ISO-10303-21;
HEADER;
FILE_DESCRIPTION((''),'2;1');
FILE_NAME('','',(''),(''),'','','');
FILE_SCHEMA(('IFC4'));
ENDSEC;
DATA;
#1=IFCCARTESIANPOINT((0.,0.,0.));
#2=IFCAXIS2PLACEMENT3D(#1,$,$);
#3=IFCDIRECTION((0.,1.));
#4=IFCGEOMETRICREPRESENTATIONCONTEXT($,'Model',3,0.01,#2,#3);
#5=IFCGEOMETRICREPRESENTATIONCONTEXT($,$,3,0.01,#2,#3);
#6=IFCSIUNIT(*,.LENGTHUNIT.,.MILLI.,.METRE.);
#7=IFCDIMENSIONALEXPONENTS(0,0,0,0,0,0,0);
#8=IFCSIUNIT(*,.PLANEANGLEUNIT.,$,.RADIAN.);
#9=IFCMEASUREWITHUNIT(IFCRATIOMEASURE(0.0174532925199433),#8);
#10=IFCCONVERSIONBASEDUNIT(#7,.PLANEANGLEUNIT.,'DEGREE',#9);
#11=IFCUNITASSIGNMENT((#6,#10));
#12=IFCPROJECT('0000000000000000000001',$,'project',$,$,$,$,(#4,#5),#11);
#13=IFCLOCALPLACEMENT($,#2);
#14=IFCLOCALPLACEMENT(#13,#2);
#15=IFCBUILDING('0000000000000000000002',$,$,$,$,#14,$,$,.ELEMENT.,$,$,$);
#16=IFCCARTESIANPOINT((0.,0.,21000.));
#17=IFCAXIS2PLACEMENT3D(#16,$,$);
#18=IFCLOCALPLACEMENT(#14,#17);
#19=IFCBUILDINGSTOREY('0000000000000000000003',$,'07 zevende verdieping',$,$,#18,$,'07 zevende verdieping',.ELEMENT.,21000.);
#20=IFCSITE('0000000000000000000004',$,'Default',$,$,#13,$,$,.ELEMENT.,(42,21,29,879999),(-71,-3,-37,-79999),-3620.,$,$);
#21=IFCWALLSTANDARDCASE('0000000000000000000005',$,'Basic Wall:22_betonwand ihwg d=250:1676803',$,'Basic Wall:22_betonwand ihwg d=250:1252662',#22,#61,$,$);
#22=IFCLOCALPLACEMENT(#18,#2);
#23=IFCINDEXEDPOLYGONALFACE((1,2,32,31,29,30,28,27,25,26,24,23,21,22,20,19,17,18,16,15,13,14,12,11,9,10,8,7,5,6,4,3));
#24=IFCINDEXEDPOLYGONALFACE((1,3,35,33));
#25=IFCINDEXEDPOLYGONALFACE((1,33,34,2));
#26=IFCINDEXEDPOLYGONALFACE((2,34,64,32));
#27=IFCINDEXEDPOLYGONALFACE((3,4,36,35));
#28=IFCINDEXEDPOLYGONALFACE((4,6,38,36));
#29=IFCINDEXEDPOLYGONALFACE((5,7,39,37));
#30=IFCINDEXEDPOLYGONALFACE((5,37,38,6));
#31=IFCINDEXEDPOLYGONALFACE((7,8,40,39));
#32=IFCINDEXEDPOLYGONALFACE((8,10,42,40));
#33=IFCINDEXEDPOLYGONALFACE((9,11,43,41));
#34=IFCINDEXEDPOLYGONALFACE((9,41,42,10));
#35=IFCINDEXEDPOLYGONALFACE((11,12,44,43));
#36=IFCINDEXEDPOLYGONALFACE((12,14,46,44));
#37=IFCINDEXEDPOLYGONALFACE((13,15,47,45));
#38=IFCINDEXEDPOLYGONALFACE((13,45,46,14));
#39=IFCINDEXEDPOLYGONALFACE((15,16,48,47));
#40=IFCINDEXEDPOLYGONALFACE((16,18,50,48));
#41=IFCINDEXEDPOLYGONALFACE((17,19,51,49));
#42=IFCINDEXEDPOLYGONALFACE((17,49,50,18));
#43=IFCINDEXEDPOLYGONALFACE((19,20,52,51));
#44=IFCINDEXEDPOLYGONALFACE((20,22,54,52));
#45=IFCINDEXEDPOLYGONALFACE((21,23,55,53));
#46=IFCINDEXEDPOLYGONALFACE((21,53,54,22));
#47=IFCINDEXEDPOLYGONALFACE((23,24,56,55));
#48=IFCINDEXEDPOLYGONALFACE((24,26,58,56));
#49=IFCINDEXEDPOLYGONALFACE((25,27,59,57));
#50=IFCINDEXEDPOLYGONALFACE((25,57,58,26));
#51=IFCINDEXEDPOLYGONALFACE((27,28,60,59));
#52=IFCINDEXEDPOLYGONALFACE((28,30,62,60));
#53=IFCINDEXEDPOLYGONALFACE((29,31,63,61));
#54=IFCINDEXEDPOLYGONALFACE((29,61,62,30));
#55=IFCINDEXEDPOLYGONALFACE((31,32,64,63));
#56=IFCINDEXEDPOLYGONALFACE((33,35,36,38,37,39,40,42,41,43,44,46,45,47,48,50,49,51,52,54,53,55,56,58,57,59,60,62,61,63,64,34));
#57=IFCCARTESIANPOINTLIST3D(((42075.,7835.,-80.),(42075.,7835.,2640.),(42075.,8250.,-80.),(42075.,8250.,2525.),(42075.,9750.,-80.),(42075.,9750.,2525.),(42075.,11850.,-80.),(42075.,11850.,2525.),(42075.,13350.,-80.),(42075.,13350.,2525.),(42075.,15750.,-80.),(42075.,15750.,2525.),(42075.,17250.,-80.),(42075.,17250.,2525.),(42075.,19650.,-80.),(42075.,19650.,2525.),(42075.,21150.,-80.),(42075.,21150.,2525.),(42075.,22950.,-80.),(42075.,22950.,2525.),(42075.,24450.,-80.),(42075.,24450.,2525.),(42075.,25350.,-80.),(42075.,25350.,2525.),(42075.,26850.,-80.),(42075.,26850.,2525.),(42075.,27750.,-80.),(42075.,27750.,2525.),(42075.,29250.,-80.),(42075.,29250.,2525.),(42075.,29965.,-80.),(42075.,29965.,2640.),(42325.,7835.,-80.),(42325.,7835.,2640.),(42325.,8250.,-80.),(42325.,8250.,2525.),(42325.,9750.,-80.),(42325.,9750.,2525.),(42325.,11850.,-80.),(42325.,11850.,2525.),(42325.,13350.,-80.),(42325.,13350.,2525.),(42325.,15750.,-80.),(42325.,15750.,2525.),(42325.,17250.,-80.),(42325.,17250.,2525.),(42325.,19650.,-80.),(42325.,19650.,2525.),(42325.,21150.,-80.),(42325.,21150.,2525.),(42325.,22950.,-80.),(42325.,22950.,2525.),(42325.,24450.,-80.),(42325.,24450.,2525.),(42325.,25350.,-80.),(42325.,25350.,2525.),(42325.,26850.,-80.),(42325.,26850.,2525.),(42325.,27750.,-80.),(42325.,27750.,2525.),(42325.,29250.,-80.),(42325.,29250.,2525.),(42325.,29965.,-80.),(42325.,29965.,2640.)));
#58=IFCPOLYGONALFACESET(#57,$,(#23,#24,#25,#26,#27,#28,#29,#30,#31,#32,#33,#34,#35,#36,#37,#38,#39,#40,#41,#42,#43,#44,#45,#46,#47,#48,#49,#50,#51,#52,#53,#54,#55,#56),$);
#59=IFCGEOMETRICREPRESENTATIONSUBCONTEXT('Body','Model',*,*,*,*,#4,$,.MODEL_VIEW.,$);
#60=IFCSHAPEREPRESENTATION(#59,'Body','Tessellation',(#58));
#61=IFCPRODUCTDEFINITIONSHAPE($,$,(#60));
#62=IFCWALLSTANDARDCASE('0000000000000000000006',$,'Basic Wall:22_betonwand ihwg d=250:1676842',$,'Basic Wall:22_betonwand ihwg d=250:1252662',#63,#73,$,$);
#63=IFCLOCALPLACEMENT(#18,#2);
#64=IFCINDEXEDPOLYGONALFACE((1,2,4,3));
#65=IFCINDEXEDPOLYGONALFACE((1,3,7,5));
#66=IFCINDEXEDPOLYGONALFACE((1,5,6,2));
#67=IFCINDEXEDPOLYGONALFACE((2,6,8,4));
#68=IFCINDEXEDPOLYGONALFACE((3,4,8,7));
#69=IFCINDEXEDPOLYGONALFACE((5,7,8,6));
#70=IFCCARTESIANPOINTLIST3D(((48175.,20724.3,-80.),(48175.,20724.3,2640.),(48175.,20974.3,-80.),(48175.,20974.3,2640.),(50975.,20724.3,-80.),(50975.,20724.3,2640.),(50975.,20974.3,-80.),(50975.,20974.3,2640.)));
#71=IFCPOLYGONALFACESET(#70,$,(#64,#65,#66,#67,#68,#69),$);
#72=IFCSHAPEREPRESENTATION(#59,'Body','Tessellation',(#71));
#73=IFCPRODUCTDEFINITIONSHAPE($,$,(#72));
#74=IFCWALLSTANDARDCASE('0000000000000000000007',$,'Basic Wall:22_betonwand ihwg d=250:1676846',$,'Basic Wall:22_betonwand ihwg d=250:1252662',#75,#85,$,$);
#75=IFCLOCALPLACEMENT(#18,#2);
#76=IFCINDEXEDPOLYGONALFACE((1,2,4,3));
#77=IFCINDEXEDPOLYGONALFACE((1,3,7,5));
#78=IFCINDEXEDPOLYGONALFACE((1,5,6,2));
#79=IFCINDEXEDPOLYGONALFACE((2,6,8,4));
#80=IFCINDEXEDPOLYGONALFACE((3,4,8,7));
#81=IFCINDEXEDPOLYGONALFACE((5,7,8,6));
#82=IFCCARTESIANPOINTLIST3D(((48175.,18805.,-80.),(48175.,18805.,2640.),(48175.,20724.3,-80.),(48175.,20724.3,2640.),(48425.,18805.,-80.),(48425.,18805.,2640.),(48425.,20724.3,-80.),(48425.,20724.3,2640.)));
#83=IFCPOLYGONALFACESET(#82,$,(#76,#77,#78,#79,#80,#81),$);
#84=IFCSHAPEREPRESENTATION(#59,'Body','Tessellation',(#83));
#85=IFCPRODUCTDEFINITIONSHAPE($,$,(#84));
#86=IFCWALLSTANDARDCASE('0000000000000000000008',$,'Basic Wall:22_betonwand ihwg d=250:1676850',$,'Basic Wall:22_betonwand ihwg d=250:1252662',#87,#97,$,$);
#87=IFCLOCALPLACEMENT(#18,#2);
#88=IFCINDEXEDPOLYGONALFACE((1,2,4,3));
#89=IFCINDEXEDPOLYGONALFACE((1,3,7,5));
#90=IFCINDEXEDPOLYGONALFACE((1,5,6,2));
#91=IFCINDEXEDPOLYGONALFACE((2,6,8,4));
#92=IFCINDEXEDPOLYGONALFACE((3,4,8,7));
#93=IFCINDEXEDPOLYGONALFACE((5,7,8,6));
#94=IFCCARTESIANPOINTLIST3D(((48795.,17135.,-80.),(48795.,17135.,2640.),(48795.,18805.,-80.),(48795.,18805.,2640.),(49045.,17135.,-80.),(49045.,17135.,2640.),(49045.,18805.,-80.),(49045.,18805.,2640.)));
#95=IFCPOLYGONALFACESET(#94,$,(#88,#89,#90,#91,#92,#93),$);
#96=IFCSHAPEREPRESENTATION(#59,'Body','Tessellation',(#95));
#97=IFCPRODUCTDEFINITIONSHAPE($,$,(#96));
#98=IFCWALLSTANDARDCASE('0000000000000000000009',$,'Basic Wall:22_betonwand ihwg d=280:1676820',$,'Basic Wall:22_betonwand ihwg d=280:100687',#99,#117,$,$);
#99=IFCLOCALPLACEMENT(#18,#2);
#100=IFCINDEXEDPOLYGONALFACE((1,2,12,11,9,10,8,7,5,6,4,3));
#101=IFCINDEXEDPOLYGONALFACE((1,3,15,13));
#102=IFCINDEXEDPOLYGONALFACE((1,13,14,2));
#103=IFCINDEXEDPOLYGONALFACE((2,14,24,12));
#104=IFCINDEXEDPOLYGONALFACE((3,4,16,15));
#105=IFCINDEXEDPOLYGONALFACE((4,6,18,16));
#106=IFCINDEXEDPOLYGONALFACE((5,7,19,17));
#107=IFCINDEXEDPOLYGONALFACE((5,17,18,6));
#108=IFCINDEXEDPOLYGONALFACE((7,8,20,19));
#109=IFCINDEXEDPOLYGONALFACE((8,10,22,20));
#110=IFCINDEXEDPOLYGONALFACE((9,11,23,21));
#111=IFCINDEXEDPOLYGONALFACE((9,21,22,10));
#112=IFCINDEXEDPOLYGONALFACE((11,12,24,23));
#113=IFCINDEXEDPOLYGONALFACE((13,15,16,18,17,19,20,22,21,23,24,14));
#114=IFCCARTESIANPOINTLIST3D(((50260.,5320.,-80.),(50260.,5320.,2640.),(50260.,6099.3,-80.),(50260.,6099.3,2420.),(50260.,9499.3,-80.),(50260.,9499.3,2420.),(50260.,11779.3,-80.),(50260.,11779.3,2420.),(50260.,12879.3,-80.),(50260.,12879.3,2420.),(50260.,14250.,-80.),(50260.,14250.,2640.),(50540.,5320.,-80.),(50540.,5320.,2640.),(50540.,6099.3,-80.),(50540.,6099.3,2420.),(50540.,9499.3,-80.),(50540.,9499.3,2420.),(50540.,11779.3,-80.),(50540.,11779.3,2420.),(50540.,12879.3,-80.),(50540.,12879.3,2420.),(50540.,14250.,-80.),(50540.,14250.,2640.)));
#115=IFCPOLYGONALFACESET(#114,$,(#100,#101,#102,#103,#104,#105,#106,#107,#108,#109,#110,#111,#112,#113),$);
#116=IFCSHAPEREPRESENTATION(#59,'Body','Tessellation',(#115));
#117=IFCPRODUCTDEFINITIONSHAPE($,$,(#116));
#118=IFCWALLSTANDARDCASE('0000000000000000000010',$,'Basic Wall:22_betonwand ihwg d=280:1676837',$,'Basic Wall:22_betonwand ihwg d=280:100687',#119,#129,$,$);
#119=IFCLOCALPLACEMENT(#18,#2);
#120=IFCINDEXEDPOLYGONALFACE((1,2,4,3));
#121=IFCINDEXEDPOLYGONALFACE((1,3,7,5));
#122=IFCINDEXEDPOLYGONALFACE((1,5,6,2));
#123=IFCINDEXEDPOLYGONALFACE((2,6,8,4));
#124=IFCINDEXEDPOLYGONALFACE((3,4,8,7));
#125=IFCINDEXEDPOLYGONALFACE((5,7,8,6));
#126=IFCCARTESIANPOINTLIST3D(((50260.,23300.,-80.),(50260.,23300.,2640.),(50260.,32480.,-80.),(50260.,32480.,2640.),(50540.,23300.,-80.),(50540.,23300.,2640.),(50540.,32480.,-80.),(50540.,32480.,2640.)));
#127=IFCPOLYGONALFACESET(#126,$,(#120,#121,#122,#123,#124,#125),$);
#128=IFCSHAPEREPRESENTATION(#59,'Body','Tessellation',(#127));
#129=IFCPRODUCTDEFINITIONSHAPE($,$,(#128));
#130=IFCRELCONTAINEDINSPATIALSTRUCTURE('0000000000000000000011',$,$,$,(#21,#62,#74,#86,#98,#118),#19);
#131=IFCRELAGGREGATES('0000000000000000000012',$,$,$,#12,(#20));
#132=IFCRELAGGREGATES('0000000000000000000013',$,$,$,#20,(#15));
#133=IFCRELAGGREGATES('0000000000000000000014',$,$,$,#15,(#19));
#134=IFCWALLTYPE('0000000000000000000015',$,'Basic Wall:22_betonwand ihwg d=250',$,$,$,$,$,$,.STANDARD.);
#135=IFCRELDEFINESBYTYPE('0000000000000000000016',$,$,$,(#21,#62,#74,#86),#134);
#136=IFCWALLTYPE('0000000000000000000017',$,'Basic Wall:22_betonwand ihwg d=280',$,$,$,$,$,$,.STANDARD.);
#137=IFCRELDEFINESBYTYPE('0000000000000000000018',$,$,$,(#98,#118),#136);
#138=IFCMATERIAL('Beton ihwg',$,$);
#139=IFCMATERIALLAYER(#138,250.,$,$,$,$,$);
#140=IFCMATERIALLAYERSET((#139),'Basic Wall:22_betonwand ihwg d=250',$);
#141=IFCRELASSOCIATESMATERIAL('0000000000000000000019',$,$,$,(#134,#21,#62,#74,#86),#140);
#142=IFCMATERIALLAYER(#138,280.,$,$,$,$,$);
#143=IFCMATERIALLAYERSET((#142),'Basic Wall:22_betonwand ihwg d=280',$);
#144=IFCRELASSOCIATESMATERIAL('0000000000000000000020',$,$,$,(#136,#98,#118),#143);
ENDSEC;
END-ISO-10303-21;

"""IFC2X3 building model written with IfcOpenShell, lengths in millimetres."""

from ifc_helpers import new_model, entity, si_unit, converted_unit, direction, frame, frame_2d, origin, place, context, subcontext, project, spatial, rectangle, extrude, material, layer, layer_set, layer_usage, type_object, element, save


model = new_model("IFC2X3")

# Units and contexts
model_context = context("Model", 3, precision=0.01, world=origin(), true_north=direction((0.0, 1.0)))
context_of_model = context(None, 3, precision=0.01, world=origin(), true_north=direction((0.0, 1.0)))
body_context = subcontext(model_context, "Body", "Model", "MODEL_VIEW")
ifc_project = project(units=[si_unit("LENGTHUNIT", "METRE", prefix="MILLI"), converted_unit("PLANEANGLEUNIT", "DEGREE", entity("IfcRatioMeasure", 0.0174532925199433), si_unit("PLANEANGLEUNIT", "RADIAN"), dimensions=[0, 0, 0, 0, 0, 0, 0])], contexts=[model_context, context_of_model])

# Site, building, storey
site_placement = place(None, origin())
site = spatial("IfcSite", under=ifc_project, at=site_placement, Name="Default", CompositionType="ELEMENT", RefLatitude=(42, 21, 29, 879999), RefLongitude=(-71, -3, -37, -79999), RefElevation=-3620.0)
building_placement = place(site_placement, origin())
building = spatial("IfcBuilding", under=site, at=building_placement, CompositionType="ELEMENT")
storey_placement = place(building_placement, frame((0.0, 0.0, 21000.0)))
storey = spatial("IfcBuildingStorey", under=building, at=storey_placement, Name="07 zevende verdieping", LongName="07 zevende verdieping", CompositionType="ELEMENT", Elevation=21000.0)

# Shared definitions
ifc_material_1 = material(Name="Beton ihwg")

# Wall, openings
ifc_layer_1 = layer(ifc_material_1, 250.0)
ifc_layer_set_1 = layer_set([ifc_layer_1], Name="Basic Wall:22_betonwand ihwg d=250")
ifc_layer_usage_1 = layer_usage(ifc_layer_set_1, "AXIS2", "POSITIVE", -125.0)
wall_type_1 = type_object("IfcWallType", Name="Basic Wall:22_betonwand ihwg d=250", PredefinedType="STANDARD", material=ifc_layer_set_1)
wall_1_placement = place(storey_placement, frame((42200.0, 29965.0, -80.0), z_axis=(0.0, 0.0, 1.0), x_axis=(0.0, -1.0, 0.0)))
wall_1 = element("IfcWallStandardCase", 1, at=wall_1_placement, inside=storey, type_object=wall_type_1, material=ifc_layer_usage_1, Name="Basic Wall:22_betonwand ihwg d=250:1676803", ObjectType="Basic Wall:22_betonwand ihwg d=250:1252662", context=body_context, shape_type="SweptSolid", body=[
    extrude(rectangle(XDim=22130.0, YDim=250.0, at=frame_2d((11065.0, 0.0), x_axis=(-1.0, 0.0))), origin(), (0.0, 0.0, 1.0), 2720.0),
])
opening_1_placement = place(wall_1_placement, frame((29965.0, -42200.0, 80.0), z_axis=(0.0, 0.0, 1.0), x_axis=(0.0, 1.0, 0.0)))
element("IfcOpeningElement", 2, at=opening_1_placement, cuts=wall_1, ObjectType="Opening", context=body_context, shape_type="SweptSolid", body=[
    extrude(rectangle(XDim=2605.0, YDim=1500.0, at=frame_2d((0.0, 0.0), x_axis=(1.0, 0.0))), frame((40801.0, 28500.0, 1222.5), z_axis=(1.0, 0.0, 0.0), x_axis=(0.0, 0.0, -1.0)), (0.0, 0.0, 1.0), 3048.0),
])
opening_2_placement = place(wall_1_placement, frame((29965.0, -42200.0, 80.0), z_axis=(0.0, 0.0, 1.0), x_axis=(0.0, 1.0, 0.0)))
element("IfcOpeningElement", 3, at=opening_2_placement, cuts=wall_1, ObjectType="Opening", context=body_context, shape_type="SweptSolid", body=[
    extrude(rectangle(XDim=2605.0, YDim=1500.0, at=frame_2d((0.0, 0.0), x_axis=(1.0, 0.0))), frame((40801.0, 26100.0, 1222.5), z_axis=(1.0, 0.0, 0.0), x_axis=(0.0, 0.0, -1.0)), (0.0, 0.0, 1.0), 3048.0),
])
opening_3_placement = place(wall_1_placement, frame((29965.0, -42200.0, 80.0), z_axis=(0.0, 0.0, 1.0), x_axis=(0.0, 1.0, 0.0)))
element("IfcOpeningElement", 4, at=opening_3_placement, cuts=wall_1, ObjectType="Opening", context=body_context, shape_type="SweptSolid", body=[
    extrude(rectangle(XDim=2605.0, YDim=1500.0, at=frame_2d((0.0, 0.0), x_axis=(1.0, 0.0))), frame((40801.0, 23700.0, 1222.5), z_axis=(1.0, 0.0, 0.0), x_axis=(0.0, 0.0, -1.0)), (0.0, 0.0, 1.0), 3048.0),
])
opening_4_placement = place(wall_1_placement, frame((29965.0, -42200.0, 80.0), z_axis=(0.0, 0.0, 1.0), x_axis=(0.0, 1.0, 0.0)))
element("IfcOpeningElement", 5, at=opening_4_placement, cuts=wall_1, ObjectType="Opening", context=body_context, shape_type="SweptSolid", body=[
    extrude(rectangle(XDim=2605.0, YDim=1500.0, at=frame_2d((0.0, 0.0), x_axis=(1.0, 0.0))), frame((40801.0, 20400.0, 1222.5), z_axis=(1.0, 0.0, 0.0), x_axis=(0.0, 0.0, -1.0)), (0.0, 0.0, 1.0), 3048.0),
])
opening_5_placement = place(wall_1_placement, frame((29965.0, -42200.0, 80.0), z_axis=(0.0, 0.0, 1.0), x_axis=(0.0, 1.0, 0.0)))
element("IfcOpeningElement", 6, at=opening_5_placement, cuts=wall_1, ObjectType="Opening", context=body_context, shape_type="SweptSolid", body=[
    extrude(rectangle(XDim=2605.0, YDim=1500.0, at=frame_2d((0.0, 0.0), x_axis=(1.0, 0.0))), frame((40801.0, 12600.0, 1222.5), z_axis=(1.0, 0.0, 0.0), x_axis=(0.0, 0.0, -1.0)), (0.0, 0.0, 1.0), 3048.0),
])
opening_6_placement = place(wall_1_placement, frame((29965.0, -42200.0, -2920.0), z_axis=(0.0, 0.0, 1.0), x_axis=(0.0, 1.0, 0.0)))
element("IfcOpeningElement", 7, at=opening_6_placement, cuts=wall_1, ObjectType="Opening", context=body_context, shape_type="SweptSolid", body=[
    extrude(rectangle(XDim=2605.0, YDim=1500.0, at=frame_2d((0.0, 0.0), x_axis=(1.0, 0.0))), frame((40801.0, 9000.0, 4222.5), z_axis=(1.0, 0.0, 0.0), x_axis=(0.0, 0.0, -1.0)), (0.0, 0.0, 1.0), 3048.0),
])
opening_7_placement = place(wall_1_placement, frame((29965.0, -42200.0, 80.0), z_axis=(0.0, 0.0, 1.0), x_axis=(0.0, 1.0, 0.0)))
element("IfcOpeningElement", 8, at=opening_7_placement, cuts=wall_1, ObjectType="Opening", context=body_context, shape_type="SweptSolid", body=[
    extrude(rectangle(XDim=2605.0, YDim=1500.0, at=frame_2d((0.0, 0.0), x_axis=(0.0, 1.0))), frame((40551.0, 16500.0, 1222.5), z_axis=(1.0, 0.0, 0.0), x_axis=(0.0, -1.0, 0.0)), (0.0, 0.0, 1.0), 3048.0),
])

# Walls
ifc_layer_usage_2 = layer_usage(ifc_layer_set_1, "AXIS2", "POSITIVE", -125.0)
wall_2_placement = place(storey_placement, frame((50975.0, 20849.3, -80.0), z_axis=(0.0, 0.0, 1.0), x_axis=(-1.0, 0.0, 0.0)))
element("IfcWallStandardCase", 9, at=wall_2_placement, inside=storey, type_object=wall_type_1, material=ifc_layer_usage_2, Name="Basic Wall:22_betonwand ihwg d=250:1676842", ObjectType="Basic Wall:22_betonwand ihwg d=250:1252662", context=body_context, shape_type="SweptSolid", body=[
    extrude(rectangle(XDim=2800.0, YDim=250.0, at=frame_2d((1400.0, 0.0), x_axis=(-1.0, 0.0))), origin(), (0.0, 0.0, 1.0), 2720.0),
])
ifc_layer_usage_3 = layer_usage(ifc_layer_set_1, "AXIS2", "POSITIVE", -125.0)
wall_3_placement = place(storey_placement, frame((48300.0, 20724.3, -80.0), z_axis=(0.0, 0.0, 1.0), x_axis=(0.0, -1.0, 0.0)))
element("IfcWallStandardCase", 10, at=wall_3_placement, inside=storey, type_object=wall_type_1, material=ifc_layer_usage_3, Name="Basic Wall:22_betonwand ihwg d=250:1676846", ObjectType="Basic Wall:22_betonwand ihwg d=250:1252662", context=body_context, shape_type="SweptSolid", body=[
    extrude(rectangle(XDim=1919.3, YDim=250.0, at=frame_2d((959.6, 0.0), x_axis=(-1.0, 0.0))), origin(), (0.0, 0.0, 1.0), 2720.0),
])
ifc_layer_usage_4 = layer_usage(ifc_layer_set_1, "AXIS2", "POSITIVE", -125.0)
wall_4_placement = place(storey_placement, frame((48920.0, 18805.0, -80.0), z_axis=(0.0, 0.0, 1.0), x_axis=(0.0, -1.0, 0.0)))
element("IfcWallStandardCase", 11, at=wall_4_placement, inside=storey, type_object=wall_type_1, material=ifc_layer_usage_4, Name="Basic Wall:22_betonwand ihwg d=250:1676850", ObjectType="Basic Wall:22_betonwand ihwg d=250:1252662", context=body_context, shape_type="SweptSolid", body=[
    extrude(rectangle(XDim=1670.0, YDim=250.0, at=frame_2d((835.0, 0.0), x_axis=(-1.0, 0.0))), origin(), (0.0, 0.0, 1.0), 2720.0),
])

# Wall, openings
ifc_layer_2 = layer(ifc_material_1, 280.0)
ifc_layer_set_2 = layer_set([ifc_layer_2], Name="Basic Wall:22_betonwand ihwg d=280")
ifc_layer_usage_5 = layer_usage(ifc_layer_set_2, "AXIS2", "NEGATIVE", 140.0)
wall_type_2 = type_object("IfcWallType", Name="Basic Wall:22_betonwand ihwg d=280", PredefinedType="STANDARD", material=ifc_layer_set_2)
wall_5_placement = place(storey_placement, frame((50400.0, 14250.0, -80.0), z_axis=(0.0, 0.0, 1.0), x_axis=(0.0, -1.0, 0.0)))
wall_5 = element("IfcWallStandardCase", 12, at=wall_5_placement, inside=storey, type_object=wall_type_2, material=ifc_layer_usage_5, Name="Basic Wall:22_betonwand ihwg d=280:1676820", ObjectType="Basic Wall:22_betonwand ihwg d=280:100687", context=body_context, shape_type="SweptSolid", body=[
    extrude(rectangle(XDim=8930.0, YDim=280.0, at=frame_2d((4465.0, 0.0), x_axis=(-1.0, 0.0))), origin(), (0.0, 0.0, 1.0), 2720.0),
])
opening_8_placement = place(wall_5_placement, frame((14250.0, -50400.0, 80.0), z_axis=(0.0, 0.0, 1.0), x_axis=(0.0, 1.0, 0.0)))
element("IfcOpeningElement", 13, at=opening_8_placement, cuts=wall_5, ObjectType="Opening", context=body_context, shape_type="SweptSolid", body=[
    extrude(rectangle(XDim=2500.0, YDim=3400.0, at=frame_2d((0.0, 0.0), x_axis=(1.0, 0.0))), frame((50000.0, 7799.3, 1170.0), z_axis=(1.0, 0.0, 0.0), x_axis=(0.0, 0.0, -1.0)), (0.0, 0.0, 1.0), 800.0),
])
opening_9_placement = place(wall_5_placement, frame((14250.0, -50400.0, 80.0), z_axis=(0.0, 0.0, 1.0), x_axis=(0.0, 1.0, 0.0)))
element("IfcOpeningElement", 14, at=opening_9_placement, cuts=wall_5, ObjectType="Opening", context=body_context, shape_type="SweptSolid", body=[
    extrude(rectangle(XDim=2500.0, YDim=1100.0, at=frame_2d((0.0, 0.0), x_axis=(0.0, 1.0))), frame((50000.0, 12329.3, 1170.0), z_axis=(1.0, 0.0, 0.0), x_axis=(0.0, -1.0, 0.0)), (0.0, 0.0, 1.0), 800.0),
])

# Wall
ifc_layer_usage_6 = layer_usage(ifc_layer_set_2, "AXIS2", "POSITIVE", -140.0)
wall_6_placement = place(storey_placement, frame((50400.0, 23300.0, -80.0), z_axis=(0.0, 0.0, 1.0), x_axis=(0.0, 1.0, 0.0)))
element("IfcWallStandardCase", 15, at=wall_6_placement, inside=storey, type_object=wall_type_2, material=ifc_layer_usage_6, Name="Basic Wall:22_betonwand ihwg d=280:1676837", ObjectType="Basic Wall:22_betonwand ihwg d=280:100687", context=body_context, shape_type="SweptSolid", body=[
    extrude(rectangle(XDim=9180.0, YDim=280.0, at=frame_2d((4590.0, 0.0), x_axis=(-1.0, 0.0))), origin(), (0.0, 0.0, 1.0), 2720.0),
])

save(model, "model.ifc")
